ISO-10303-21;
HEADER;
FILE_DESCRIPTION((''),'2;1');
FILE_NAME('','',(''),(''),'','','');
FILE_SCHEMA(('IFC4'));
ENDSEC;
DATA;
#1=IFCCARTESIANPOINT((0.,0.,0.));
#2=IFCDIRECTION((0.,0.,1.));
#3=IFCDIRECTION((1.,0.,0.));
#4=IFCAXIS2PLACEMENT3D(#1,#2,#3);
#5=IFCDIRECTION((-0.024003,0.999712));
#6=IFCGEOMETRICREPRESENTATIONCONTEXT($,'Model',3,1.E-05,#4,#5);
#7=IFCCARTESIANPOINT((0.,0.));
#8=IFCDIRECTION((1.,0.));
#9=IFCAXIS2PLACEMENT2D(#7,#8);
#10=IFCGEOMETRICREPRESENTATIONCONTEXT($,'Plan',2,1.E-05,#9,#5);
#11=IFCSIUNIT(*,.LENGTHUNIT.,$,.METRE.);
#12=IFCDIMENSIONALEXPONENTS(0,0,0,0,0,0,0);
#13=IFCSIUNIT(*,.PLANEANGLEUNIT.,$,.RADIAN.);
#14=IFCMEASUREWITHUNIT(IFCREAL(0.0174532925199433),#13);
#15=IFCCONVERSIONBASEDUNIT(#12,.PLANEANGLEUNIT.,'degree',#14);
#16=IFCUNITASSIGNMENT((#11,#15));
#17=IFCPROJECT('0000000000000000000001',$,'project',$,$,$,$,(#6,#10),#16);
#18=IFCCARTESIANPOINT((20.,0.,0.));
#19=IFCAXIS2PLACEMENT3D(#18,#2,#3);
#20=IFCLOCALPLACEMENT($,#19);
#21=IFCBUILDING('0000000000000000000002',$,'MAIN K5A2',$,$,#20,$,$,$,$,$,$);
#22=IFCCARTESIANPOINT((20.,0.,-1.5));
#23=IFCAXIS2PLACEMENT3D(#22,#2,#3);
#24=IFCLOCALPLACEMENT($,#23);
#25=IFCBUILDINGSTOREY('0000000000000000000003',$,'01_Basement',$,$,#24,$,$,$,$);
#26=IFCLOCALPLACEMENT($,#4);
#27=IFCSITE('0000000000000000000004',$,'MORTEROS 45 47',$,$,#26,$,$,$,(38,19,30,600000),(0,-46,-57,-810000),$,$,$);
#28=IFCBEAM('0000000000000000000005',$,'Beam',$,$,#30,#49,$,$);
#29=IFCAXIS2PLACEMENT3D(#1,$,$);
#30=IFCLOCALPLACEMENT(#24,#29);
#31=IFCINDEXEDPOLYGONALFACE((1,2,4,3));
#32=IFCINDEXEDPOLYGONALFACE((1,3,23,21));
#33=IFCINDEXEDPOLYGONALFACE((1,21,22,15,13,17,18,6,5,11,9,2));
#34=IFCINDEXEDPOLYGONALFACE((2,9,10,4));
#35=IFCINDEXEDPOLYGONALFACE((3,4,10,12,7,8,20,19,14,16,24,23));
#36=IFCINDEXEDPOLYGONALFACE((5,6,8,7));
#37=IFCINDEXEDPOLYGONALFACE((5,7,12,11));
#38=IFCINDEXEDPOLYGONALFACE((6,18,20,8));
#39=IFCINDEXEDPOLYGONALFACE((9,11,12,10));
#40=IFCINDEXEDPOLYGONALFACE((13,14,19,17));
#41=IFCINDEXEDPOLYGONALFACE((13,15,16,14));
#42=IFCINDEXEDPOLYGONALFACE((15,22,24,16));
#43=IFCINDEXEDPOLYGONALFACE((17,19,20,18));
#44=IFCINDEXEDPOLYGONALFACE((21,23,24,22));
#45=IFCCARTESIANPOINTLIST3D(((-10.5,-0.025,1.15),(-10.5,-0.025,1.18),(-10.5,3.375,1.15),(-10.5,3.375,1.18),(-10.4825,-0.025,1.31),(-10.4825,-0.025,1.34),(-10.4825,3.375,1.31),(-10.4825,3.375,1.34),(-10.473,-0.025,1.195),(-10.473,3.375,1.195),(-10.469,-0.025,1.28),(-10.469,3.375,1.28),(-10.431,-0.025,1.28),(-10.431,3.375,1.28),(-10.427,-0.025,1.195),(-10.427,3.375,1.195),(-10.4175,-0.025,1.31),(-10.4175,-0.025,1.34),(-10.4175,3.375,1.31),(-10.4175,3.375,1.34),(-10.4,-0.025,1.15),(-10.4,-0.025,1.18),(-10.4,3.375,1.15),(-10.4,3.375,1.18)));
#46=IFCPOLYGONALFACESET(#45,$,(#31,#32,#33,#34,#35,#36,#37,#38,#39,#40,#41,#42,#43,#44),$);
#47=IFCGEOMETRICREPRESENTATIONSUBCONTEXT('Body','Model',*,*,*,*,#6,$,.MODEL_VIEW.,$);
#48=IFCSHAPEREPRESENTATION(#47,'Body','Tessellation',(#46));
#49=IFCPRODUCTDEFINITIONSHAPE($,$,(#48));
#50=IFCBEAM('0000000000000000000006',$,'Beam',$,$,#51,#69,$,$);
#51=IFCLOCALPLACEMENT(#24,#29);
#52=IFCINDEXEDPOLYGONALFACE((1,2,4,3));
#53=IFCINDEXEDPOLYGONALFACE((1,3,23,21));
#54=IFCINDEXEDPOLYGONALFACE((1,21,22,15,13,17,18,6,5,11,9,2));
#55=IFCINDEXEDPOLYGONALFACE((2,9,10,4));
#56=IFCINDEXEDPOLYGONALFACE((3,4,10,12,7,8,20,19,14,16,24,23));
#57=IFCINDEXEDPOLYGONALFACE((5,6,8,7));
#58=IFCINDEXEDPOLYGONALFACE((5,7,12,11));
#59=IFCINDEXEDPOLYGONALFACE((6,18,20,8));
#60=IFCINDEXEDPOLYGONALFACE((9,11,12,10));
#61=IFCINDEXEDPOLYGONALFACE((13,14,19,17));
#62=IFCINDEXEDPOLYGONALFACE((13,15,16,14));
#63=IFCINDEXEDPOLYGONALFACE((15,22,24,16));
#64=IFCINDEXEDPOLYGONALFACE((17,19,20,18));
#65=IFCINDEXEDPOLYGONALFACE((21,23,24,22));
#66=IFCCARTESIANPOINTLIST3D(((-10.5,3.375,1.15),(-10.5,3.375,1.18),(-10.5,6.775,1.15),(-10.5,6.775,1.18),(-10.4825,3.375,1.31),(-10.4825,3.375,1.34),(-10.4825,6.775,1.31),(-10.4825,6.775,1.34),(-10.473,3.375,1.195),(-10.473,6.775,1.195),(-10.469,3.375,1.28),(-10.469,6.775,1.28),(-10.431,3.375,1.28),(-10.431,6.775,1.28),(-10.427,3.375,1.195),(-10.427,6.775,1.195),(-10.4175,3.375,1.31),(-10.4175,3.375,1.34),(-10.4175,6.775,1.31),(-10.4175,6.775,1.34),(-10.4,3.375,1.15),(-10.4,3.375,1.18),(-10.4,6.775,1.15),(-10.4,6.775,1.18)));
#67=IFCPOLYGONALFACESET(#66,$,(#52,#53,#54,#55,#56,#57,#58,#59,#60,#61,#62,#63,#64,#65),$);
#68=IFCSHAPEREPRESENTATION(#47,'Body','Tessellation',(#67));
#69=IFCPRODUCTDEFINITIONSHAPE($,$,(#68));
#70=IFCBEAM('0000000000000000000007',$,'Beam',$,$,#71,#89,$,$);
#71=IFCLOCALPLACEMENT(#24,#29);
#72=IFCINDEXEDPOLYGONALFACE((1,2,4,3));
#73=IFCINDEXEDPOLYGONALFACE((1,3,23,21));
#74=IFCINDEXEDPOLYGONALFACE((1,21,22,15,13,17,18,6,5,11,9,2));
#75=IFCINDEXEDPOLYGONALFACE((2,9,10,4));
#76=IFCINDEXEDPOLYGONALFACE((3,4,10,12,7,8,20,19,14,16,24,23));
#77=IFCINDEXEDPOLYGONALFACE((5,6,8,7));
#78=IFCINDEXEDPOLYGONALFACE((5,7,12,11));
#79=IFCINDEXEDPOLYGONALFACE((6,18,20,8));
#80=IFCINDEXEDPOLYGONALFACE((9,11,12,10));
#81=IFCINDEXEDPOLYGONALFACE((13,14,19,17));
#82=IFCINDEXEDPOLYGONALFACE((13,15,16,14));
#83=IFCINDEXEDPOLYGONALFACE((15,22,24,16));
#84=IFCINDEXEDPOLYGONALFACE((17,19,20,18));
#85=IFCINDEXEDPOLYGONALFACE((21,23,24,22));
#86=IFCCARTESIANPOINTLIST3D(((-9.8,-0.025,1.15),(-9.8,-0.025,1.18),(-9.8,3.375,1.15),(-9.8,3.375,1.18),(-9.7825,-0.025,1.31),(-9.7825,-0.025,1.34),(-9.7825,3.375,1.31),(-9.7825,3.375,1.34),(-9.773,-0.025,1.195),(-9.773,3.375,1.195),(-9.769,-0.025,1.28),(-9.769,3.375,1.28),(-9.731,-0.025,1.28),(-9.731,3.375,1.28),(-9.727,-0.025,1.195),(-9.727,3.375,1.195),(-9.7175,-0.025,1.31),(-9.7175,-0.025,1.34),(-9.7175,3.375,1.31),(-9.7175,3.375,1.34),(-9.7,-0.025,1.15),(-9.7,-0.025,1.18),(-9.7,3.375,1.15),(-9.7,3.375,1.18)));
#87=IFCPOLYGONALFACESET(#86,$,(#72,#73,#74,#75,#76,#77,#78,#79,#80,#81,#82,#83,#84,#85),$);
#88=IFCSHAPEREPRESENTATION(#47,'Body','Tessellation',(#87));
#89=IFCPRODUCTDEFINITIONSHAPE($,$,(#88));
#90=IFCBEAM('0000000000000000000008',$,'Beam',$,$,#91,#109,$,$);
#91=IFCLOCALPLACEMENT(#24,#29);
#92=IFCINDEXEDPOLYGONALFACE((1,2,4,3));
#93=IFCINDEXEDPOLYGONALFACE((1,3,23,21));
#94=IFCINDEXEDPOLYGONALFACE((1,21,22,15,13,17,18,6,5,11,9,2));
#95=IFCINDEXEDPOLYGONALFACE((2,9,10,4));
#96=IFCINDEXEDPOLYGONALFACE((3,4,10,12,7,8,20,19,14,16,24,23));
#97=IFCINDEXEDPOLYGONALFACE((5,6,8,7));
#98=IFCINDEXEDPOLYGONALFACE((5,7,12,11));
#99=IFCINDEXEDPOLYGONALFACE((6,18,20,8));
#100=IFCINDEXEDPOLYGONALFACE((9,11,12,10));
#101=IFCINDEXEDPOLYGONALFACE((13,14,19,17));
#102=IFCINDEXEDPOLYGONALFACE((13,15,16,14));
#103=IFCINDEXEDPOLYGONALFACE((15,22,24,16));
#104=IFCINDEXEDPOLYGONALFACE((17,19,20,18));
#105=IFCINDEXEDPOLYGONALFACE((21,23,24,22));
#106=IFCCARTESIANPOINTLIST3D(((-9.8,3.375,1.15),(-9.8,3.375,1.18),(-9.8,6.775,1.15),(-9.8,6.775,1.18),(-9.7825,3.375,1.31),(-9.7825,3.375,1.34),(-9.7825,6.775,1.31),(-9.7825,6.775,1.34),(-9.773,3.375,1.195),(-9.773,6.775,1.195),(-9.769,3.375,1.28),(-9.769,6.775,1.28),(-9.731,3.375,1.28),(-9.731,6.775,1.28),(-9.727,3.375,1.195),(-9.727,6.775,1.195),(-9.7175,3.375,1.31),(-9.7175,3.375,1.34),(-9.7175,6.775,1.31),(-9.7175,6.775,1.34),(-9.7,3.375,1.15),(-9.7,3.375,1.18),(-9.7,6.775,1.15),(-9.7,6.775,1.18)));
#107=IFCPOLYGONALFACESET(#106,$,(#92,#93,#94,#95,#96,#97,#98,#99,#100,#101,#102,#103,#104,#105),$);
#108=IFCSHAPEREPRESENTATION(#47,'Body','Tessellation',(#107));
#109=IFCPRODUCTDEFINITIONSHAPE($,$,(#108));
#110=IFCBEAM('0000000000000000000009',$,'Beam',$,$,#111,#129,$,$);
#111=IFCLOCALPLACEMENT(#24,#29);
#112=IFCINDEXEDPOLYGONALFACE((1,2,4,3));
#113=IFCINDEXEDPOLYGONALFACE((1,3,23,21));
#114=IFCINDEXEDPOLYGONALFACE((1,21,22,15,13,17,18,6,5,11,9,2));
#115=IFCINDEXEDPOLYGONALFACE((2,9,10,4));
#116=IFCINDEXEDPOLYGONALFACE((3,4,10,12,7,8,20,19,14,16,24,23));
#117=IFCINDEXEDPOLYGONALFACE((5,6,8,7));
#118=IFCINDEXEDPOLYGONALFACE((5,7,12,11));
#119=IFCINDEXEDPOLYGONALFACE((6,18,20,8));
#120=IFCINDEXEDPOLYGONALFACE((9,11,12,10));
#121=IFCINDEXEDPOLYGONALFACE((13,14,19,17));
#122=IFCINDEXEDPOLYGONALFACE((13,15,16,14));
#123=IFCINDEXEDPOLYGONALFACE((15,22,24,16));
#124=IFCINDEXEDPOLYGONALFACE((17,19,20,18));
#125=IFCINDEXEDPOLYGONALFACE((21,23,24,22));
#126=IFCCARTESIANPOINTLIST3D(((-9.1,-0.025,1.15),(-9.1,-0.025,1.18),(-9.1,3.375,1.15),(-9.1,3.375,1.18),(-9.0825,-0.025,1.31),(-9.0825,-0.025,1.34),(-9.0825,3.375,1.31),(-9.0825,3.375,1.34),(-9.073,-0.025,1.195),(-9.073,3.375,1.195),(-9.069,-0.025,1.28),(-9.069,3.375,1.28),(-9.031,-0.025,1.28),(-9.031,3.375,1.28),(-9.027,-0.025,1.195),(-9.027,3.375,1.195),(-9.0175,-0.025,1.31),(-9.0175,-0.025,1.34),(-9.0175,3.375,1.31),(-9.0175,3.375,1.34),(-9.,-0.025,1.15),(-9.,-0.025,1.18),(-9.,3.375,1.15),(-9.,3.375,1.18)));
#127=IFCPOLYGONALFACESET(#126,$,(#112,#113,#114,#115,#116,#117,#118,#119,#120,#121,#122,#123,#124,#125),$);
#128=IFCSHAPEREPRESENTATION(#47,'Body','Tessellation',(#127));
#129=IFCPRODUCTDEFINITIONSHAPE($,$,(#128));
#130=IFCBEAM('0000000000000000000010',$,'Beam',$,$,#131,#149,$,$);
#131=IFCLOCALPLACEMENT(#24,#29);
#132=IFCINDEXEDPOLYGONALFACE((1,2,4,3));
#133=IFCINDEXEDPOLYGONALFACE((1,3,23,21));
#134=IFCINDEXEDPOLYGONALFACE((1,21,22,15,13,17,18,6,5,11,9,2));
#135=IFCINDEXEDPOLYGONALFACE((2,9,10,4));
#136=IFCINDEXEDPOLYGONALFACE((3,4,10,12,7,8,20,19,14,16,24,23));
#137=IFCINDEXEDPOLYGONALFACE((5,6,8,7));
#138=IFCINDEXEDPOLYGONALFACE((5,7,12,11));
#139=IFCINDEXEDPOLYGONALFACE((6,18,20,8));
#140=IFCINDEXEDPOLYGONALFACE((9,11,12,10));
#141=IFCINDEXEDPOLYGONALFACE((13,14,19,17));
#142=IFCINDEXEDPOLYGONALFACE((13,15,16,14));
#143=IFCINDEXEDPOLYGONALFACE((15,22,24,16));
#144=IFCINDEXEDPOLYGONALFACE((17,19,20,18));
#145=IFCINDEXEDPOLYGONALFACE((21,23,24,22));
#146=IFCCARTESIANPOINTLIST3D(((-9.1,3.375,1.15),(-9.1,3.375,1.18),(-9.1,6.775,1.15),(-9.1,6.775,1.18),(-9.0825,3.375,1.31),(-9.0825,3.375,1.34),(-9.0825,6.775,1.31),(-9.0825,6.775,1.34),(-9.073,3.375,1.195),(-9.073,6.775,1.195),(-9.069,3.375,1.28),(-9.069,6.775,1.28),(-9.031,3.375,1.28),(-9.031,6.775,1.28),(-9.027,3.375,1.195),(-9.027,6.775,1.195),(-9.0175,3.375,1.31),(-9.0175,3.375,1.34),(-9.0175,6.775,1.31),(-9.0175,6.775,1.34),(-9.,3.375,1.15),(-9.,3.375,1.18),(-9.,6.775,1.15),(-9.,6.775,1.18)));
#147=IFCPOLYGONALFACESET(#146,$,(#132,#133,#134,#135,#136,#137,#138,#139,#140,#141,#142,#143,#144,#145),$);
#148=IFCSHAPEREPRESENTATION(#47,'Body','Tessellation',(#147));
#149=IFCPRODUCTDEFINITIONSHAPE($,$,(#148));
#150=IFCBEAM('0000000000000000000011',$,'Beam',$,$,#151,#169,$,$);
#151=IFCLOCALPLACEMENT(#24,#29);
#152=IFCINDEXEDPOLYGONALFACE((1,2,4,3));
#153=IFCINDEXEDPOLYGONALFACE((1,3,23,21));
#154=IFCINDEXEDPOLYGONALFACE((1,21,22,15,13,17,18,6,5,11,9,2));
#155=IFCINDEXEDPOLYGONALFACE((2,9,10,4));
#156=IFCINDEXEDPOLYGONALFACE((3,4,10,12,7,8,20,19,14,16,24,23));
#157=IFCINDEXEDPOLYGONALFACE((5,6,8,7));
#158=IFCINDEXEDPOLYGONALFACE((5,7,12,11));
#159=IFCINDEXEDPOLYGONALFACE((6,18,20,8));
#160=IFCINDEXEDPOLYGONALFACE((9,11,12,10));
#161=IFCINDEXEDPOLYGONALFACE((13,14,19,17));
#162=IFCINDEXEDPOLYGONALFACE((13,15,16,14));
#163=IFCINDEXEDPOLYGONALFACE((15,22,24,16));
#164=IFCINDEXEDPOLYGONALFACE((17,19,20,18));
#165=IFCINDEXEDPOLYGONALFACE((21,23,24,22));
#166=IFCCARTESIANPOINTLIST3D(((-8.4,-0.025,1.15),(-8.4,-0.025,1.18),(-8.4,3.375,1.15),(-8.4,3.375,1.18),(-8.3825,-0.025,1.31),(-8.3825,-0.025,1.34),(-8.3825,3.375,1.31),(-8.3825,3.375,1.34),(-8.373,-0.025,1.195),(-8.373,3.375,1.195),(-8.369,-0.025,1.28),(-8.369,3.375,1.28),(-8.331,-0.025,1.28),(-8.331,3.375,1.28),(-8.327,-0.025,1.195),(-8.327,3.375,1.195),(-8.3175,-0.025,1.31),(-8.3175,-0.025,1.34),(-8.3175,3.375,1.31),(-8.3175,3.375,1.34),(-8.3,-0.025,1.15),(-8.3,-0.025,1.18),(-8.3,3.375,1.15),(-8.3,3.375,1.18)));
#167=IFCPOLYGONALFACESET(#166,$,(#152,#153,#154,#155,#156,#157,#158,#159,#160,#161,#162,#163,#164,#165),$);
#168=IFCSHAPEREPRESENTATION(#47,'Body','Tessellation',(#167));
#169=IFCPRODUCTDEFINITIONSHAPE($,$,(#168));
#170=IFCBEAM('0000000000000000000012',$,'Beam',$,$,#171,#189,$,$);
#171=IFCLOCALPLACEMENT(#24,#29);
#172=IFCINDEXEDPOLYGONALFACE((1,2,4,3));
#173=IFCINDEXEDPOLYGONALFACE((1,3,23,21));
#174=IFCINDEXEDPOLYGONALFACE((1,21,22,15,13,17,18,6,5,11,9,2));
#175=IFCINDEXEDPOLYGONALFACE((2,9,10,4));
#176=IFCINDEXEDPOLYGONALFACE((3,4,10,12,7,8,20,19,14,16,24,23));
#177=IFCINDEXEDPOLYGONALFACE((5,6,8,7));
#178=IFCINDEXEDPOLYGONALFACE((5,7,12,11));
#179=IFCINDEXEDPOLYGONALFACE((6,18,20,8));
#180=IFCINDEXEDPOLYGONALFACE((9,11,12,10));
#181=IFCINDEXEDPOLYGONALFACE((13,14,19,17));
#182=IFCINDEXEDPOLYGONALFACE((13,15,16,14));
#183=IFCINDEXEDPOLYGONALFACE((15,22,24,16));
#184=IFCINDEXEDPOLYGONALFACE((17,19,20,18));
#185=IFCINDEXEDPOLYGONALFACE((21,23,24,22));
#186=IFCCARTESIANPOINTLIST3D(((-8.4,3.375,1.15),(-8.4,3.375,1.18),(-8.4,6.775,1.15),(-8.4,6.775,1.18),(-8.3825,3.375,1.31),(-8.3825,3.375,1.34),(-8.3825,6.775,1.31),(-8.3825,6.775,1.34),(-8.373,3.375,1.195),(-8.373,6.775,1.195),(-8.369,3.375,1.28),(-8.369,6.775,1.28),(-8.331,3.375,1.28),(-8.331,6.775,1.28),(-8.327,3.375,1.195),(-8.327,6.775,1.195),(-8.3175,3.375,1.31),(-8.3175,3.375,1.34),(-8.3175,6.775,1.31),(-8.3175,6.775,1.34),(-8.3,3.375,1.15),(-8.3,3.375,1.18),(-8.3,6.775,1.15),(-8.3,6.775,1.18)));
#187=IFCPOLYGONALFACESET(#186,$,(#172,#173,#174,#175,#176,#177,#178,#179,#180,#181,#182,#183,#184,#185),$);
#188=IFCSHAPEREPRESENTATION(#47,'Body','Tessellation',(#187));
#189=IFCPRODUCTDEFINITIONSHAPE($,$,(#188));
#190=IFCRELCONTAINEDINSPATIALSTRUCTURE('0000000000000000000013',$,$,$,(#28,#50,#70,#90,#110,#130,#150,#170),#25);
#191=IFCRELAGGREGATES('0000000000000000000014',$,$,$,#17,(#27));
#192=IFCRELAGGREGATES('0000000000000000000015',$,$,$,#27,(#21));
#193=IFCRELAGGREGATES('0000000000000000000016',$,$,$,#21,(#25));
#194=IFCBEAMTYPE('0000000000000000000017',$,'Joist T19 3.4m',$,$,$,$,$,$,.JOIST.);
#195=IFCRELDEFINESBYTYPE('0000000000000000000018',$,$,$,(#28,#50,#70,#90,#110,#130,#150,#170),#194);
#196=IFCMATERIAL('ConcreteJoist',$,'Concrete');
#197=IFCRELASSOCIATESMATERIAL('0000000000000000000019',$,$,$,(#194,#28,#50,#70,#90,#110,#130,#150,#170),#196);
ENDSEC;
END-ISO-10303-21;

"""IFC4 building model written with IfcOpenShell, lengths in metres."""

from ifc_helpers import new_model, entity, si_unit, converted_unit, direction, frame, origin_with_axes, origin_2d_with_axis, place, context, subcontext, project, spatial, indexed_curve, outline, extrude, material, material_profile, profile_set, profile_usage, type_object, element, save


model = new_model("IFC4")

# Units and contexts
model_context = context("Model", 3, precision=1e-05, world=origin_with_axes(), true_north=direction((-0.024003, 0.999712)))
plan_context = context("Plan", 2, precision=1e-05, world=origin_2d_with_axis(), true_north=direction((-0.024003, 0.999712)))
body_context_1 = subcontext(model_context, "Body", "Model", "MODEL_VIEW")
ifc_project = project(units=[si_unit("LENGTHUNIT", "METRE"), converted_unit("PLANEANGLEUNIT", "degree", entity("IfcReal", 0.0174532925199433), si_unit("PLANEANGLEUNIT", "RADIAN"), dimensions=[0, 0, 0, 0, 0, 0, 0])], contexts=[model_context, plan_context])

# Site, building, storey
site_placement = place(None, origin_with_axes())
site = spatial("IfcSite", under=ifc_project, at=site_placement, Name="MORTEROS 45 47", RefLatitude=(38, 19, 30, 600000), RefLongitude=(0, -46, -57, -810000))
building_placement = place(None, frame((20.0, 0.0, 0.0), z_axis=(0.0, 0.0, 1.0), x_axis=(1.0, 0.0, 0.0)))
building = spatial("IfcBuilding", under=site, at=building_placement, Name="MAIN K5A2")
storey_placement = place(None, frame((20.0, 0.0, -1.5), z_axis=(0.0, 0.0, 1.0), x_axis=(1.0, 0.0, 0.0)))
storey = spatial("IfcBuildingStorey", under=building, at=storey_placement, Name="01_Basement")

# Beams
ifc_material = material(Name="ConcreteJoist", Category="Concrete")
ifc_material_profile = material_profile(ifc_material, outline(indexed_curve([(0.019, 0.13), (0.023, 0.045), (0.05, 0.03), (0.05, 0.0), (-0.05, 0.0), (-0.05, 0.03), (-0.023, 0.045), (-0.019, 0.13), (-0.0325, 0.16), (-0.0325, 0.19), (0.0325, 0.19), (0.0325, 0.16), (0.019, 0.13)])))
ifc_profile_set = profile_set([ifc_material_profile], Name="JoistMaterialProfileSet")
beam_type = type_object("IfcBeamType", Name="Joist T19 3.4m", PredefinedType="JOIST", material=ifc_profile_set)
ifc_profile_usage_1 = profile_usage(ifc_profile_set, cardinal=5)
beam_1_placement = place(None, frame((9.55, -0.025, -0.35), z_axis=(0.0, 1.0, 0.0), x_axis=(-1.0, 0.0, 0.0)))
element("IfcBeam", 1, at=beam_1_placement, inside=storey, type_object=beam_type, material=ifc_profile_usage_1, Name="Beam", context=body_context_1, shape_type="SweptSolid", body=[
    extrude(outline(indexed_curve([(0.019, 0.13), (0.023, 0.045), (0.05, 0.03), (0.05, 0.0), (-0.05, 0.0), (-0.05, 0.03), (-0.023, 0.045), (-0.019, 0.13), (-0.0325, 0.16), (-0.0325, 0.19), (0.0325, 0.19), (0.0325, 0.16), (0.019, 0.13)])), origin_with_axes(), (0.0, 0.0, 1.0), 3.4),
])
ifc_profile_usage_2 = profile_usage(ifc_profile_set, cardinal=5)
beam_2_placement = place(None, frame((9.55, 3.375, -0.35), z_axis=(0.0, 1.0, 0.0), x_axis=(-1.0, 0.0, 0.0)))
element("IfcBeam", 2, at=beam_2_placement, inside=storey, type_object=beam_type, material=ifc_profile_usage_2, Name="Beam", context=body_context_1, shape_type="SweptSolid", body=[
    extrude(outline(indexed_curve([(0.019, 0.13), (0.023, 0.045), (0.05, 0.03), (0.05, 0.0), (-0.05, 0.0), (-0.05, 0.03), (-0.023, 0.045), (-0.019, 0.13), (-0.0325, 0.16), (-0.0325, 0.19), (0.0325, 0.19), (0.0325, 0.16), (0.019, 0.13)])), origin_with_axes(), (0.0, 0.0, 1.0), 3.4),
])
ifc_profile_usage_3 = profile_usage(ifc_profile_set, cardinal=5)
beam_3_placement = place(None, frame((10.25, -0.025, -0.35), z_axis=(0.0, 1.0, 0.0), x_axis=(-1.0, 0.0, 0.0)))
element("IfcBeam", 3, at=beam_3_placement, inside=storey, type_object=beam_type, material=ifc_profile_usage_3, Name="Beam", context=body_context_1, shape_type="SweptSolid", body=[
    extrude(outline(indexed_curve([(0.019, 0.13), (0.023, 0.045), (0.05, 0.03), (0.05, 0.0), (-0.05, 0.0), (-0.05, 0.03), (-0.023, 0.045), (-0.019, 0.13), (-0.0325, 0.16), (-0.0325, 0.19), (0.0325, 0.19), (0.0325, 0.16), (0.019, 0.13)])), origin_with_axes(), (0.0, 0.0, 1.0), 3.4),
])
ifc_profile_usage_4 = profile_usage(ifc_profile_set, cardinal=5)
beam_4_placement = place(None, frame((10.25, 3.375, -0.35), z_axis=(0.0, 1.0, 0.0), x_axis=(-1.0, 0.0, 0.0)))
element("IfcBeam", 4, at=beam_4_placement, inside=storey, type_object=beam_type, material=ifc_profile_usage_4, Name="Beam", context=body_context_1, shape_type="SweptSolid", body=[
    extrude(outline(indexed_curve([(0.019, 0.13), (0.023, 0.045), (0.05, 0.03), (0.05, 0.0), (-0.05, 0.0), (-0.05, 0.03), (-0.023, 0.045), (-0.019, 0.13), (-0.0325, 0.16), (-0.0325, 0.19), (0.0325, 0.19), (0.0325, 0.16), (0.019, 0.13)])), origin_with_axes(), (0.0, 0.0, 1.0), 3.4),
])
ifc_profile_usage_5 = profile_usage(ifc_profile_set, cardinal=5)
beam_5_placement = place(None, frame((10.95, -0.025, -0.35), z_axis=(0.0, 1.0, 0.0), x_axis=(-1.0, 0.0, 0.0)))
element("IfcBeam", 5, at=beam_5_placement, inside=storey, type_object=beam_type, material=ifc_profile_usage_5, Name="Beam", context=body_context_1, shape_type="SweptSolid", body=[
    extrude(outline(indexed_curve([(0.019, 0.13), (0.023, 0.045), (0.05, 0.03), (0.05, 0.0), (-0.05, 0.0), (-0.05, 0.03), (-0.023, 0.045), (-0.019, 0.13), (-0.0325, 0.16), (-0.0325, 0.19), (0.0325, 0.19), (0.0325, 0.16), (0.019, 0.13)])), origin_with_axes(), (0.0, 0.0, 1.0), 3.4),
])
ifc_profile_usage_6 = profile_usage(ifc_profile_set, cardinal=5)
beam_6_placement = place(None, frame((10.95, 3.375, -0.35), z_axis=(0.0, 1.0, 0.0), x_axis=(-1.0, 0.0, 0.0)))
element("IfcBeam", 6, at=beam_6_placement, inside=storey, type_object=beam_type, material=ifc_profile_usage_6, Name="Beam", context=body_context_1, shape_type="SweptSolid", body=[
    extrude(outline(indexed_curve([(0.019, 0.13), (0.023, 0.045), (0.05, 0.03), (0.05, 0.0), (-0.05, 0.0), (-0.05, 0.03), (-0.023, 0.045), (-0.019, 0.13), (-0.0325, 0.16), (-0.0325, 0.19), (0.0325, 0.19), (0.0325, 0.16), (0.019, 0.13)])), origin_with_axes(), (0.0, 0.0, 1.0), 3.4),
])
ifc_profile_usage_7 = profile_usage(ifc_profile_set, cardinal=5)
beam_7_placement = place(None, frame((11.65, -0.025, -0.35), z_axis=(0.0, 1.0, 0.0), x_axis=(-1.0, 0.0, 0.0)))
element("IfcBeam", 7, at=beam_7_placement, inside=storey, type_object=beam_type, material=ifc_profile_usage_7, Name="Beam", context=body_context_1, shape_type="SweptSolid", body=[
    extrude(outline(indexed_curve([(0.019, 0.13), (0.023, 0.045), (0.05, 0.03), (0.05, 0.0), (-0.05, 0.0), (-0.05, 0.03), (-0.023, 0.045), (-0.019, 0.13), (-0.0325, 0.16), (-0.0325, 0.19), (0.0325, 0.19), (0.0325, 0.16), (0.019, 0.13)])), origin_with_axes(), (0.0, 0.0, 1.0), 3.4),
])
ifc_profile_usage_8 = profile_usage(ifc_profile_set, cardinal=5)
beam_8_placement = place(None, frame((11.65, 3.375, -0.35), z_axis=(0.0, 1.0, 0.0), x_axis=(-1.0, 0.0, 0.0)))
element("IfcBeam", 8, at=beam_8_placement, inside=storey, type_object=beam_type, material=ifc_profile_usage_8, Name="Beam", context=body_context_1, shape_type="SweptSolid", body=[
    extrude(outline(indexed_curve([(0.019, 0.13), (0.023, 0.045), (0.05, 0.03), (0.05, 0.0), (-0.05, 0.0), (-0.05, 0.03), (-0.023, 0.045), (-0.019, 0.13), (-0.0325, 0.16), (-0.0325, 0.19), (0.0325, 0.19), (0.0325, 0.16), (0.019, 0.13)])), origin_with_axes(), (0.0, 0.0, 1.0), 3.4),
])

save(model, "model.ifc")
